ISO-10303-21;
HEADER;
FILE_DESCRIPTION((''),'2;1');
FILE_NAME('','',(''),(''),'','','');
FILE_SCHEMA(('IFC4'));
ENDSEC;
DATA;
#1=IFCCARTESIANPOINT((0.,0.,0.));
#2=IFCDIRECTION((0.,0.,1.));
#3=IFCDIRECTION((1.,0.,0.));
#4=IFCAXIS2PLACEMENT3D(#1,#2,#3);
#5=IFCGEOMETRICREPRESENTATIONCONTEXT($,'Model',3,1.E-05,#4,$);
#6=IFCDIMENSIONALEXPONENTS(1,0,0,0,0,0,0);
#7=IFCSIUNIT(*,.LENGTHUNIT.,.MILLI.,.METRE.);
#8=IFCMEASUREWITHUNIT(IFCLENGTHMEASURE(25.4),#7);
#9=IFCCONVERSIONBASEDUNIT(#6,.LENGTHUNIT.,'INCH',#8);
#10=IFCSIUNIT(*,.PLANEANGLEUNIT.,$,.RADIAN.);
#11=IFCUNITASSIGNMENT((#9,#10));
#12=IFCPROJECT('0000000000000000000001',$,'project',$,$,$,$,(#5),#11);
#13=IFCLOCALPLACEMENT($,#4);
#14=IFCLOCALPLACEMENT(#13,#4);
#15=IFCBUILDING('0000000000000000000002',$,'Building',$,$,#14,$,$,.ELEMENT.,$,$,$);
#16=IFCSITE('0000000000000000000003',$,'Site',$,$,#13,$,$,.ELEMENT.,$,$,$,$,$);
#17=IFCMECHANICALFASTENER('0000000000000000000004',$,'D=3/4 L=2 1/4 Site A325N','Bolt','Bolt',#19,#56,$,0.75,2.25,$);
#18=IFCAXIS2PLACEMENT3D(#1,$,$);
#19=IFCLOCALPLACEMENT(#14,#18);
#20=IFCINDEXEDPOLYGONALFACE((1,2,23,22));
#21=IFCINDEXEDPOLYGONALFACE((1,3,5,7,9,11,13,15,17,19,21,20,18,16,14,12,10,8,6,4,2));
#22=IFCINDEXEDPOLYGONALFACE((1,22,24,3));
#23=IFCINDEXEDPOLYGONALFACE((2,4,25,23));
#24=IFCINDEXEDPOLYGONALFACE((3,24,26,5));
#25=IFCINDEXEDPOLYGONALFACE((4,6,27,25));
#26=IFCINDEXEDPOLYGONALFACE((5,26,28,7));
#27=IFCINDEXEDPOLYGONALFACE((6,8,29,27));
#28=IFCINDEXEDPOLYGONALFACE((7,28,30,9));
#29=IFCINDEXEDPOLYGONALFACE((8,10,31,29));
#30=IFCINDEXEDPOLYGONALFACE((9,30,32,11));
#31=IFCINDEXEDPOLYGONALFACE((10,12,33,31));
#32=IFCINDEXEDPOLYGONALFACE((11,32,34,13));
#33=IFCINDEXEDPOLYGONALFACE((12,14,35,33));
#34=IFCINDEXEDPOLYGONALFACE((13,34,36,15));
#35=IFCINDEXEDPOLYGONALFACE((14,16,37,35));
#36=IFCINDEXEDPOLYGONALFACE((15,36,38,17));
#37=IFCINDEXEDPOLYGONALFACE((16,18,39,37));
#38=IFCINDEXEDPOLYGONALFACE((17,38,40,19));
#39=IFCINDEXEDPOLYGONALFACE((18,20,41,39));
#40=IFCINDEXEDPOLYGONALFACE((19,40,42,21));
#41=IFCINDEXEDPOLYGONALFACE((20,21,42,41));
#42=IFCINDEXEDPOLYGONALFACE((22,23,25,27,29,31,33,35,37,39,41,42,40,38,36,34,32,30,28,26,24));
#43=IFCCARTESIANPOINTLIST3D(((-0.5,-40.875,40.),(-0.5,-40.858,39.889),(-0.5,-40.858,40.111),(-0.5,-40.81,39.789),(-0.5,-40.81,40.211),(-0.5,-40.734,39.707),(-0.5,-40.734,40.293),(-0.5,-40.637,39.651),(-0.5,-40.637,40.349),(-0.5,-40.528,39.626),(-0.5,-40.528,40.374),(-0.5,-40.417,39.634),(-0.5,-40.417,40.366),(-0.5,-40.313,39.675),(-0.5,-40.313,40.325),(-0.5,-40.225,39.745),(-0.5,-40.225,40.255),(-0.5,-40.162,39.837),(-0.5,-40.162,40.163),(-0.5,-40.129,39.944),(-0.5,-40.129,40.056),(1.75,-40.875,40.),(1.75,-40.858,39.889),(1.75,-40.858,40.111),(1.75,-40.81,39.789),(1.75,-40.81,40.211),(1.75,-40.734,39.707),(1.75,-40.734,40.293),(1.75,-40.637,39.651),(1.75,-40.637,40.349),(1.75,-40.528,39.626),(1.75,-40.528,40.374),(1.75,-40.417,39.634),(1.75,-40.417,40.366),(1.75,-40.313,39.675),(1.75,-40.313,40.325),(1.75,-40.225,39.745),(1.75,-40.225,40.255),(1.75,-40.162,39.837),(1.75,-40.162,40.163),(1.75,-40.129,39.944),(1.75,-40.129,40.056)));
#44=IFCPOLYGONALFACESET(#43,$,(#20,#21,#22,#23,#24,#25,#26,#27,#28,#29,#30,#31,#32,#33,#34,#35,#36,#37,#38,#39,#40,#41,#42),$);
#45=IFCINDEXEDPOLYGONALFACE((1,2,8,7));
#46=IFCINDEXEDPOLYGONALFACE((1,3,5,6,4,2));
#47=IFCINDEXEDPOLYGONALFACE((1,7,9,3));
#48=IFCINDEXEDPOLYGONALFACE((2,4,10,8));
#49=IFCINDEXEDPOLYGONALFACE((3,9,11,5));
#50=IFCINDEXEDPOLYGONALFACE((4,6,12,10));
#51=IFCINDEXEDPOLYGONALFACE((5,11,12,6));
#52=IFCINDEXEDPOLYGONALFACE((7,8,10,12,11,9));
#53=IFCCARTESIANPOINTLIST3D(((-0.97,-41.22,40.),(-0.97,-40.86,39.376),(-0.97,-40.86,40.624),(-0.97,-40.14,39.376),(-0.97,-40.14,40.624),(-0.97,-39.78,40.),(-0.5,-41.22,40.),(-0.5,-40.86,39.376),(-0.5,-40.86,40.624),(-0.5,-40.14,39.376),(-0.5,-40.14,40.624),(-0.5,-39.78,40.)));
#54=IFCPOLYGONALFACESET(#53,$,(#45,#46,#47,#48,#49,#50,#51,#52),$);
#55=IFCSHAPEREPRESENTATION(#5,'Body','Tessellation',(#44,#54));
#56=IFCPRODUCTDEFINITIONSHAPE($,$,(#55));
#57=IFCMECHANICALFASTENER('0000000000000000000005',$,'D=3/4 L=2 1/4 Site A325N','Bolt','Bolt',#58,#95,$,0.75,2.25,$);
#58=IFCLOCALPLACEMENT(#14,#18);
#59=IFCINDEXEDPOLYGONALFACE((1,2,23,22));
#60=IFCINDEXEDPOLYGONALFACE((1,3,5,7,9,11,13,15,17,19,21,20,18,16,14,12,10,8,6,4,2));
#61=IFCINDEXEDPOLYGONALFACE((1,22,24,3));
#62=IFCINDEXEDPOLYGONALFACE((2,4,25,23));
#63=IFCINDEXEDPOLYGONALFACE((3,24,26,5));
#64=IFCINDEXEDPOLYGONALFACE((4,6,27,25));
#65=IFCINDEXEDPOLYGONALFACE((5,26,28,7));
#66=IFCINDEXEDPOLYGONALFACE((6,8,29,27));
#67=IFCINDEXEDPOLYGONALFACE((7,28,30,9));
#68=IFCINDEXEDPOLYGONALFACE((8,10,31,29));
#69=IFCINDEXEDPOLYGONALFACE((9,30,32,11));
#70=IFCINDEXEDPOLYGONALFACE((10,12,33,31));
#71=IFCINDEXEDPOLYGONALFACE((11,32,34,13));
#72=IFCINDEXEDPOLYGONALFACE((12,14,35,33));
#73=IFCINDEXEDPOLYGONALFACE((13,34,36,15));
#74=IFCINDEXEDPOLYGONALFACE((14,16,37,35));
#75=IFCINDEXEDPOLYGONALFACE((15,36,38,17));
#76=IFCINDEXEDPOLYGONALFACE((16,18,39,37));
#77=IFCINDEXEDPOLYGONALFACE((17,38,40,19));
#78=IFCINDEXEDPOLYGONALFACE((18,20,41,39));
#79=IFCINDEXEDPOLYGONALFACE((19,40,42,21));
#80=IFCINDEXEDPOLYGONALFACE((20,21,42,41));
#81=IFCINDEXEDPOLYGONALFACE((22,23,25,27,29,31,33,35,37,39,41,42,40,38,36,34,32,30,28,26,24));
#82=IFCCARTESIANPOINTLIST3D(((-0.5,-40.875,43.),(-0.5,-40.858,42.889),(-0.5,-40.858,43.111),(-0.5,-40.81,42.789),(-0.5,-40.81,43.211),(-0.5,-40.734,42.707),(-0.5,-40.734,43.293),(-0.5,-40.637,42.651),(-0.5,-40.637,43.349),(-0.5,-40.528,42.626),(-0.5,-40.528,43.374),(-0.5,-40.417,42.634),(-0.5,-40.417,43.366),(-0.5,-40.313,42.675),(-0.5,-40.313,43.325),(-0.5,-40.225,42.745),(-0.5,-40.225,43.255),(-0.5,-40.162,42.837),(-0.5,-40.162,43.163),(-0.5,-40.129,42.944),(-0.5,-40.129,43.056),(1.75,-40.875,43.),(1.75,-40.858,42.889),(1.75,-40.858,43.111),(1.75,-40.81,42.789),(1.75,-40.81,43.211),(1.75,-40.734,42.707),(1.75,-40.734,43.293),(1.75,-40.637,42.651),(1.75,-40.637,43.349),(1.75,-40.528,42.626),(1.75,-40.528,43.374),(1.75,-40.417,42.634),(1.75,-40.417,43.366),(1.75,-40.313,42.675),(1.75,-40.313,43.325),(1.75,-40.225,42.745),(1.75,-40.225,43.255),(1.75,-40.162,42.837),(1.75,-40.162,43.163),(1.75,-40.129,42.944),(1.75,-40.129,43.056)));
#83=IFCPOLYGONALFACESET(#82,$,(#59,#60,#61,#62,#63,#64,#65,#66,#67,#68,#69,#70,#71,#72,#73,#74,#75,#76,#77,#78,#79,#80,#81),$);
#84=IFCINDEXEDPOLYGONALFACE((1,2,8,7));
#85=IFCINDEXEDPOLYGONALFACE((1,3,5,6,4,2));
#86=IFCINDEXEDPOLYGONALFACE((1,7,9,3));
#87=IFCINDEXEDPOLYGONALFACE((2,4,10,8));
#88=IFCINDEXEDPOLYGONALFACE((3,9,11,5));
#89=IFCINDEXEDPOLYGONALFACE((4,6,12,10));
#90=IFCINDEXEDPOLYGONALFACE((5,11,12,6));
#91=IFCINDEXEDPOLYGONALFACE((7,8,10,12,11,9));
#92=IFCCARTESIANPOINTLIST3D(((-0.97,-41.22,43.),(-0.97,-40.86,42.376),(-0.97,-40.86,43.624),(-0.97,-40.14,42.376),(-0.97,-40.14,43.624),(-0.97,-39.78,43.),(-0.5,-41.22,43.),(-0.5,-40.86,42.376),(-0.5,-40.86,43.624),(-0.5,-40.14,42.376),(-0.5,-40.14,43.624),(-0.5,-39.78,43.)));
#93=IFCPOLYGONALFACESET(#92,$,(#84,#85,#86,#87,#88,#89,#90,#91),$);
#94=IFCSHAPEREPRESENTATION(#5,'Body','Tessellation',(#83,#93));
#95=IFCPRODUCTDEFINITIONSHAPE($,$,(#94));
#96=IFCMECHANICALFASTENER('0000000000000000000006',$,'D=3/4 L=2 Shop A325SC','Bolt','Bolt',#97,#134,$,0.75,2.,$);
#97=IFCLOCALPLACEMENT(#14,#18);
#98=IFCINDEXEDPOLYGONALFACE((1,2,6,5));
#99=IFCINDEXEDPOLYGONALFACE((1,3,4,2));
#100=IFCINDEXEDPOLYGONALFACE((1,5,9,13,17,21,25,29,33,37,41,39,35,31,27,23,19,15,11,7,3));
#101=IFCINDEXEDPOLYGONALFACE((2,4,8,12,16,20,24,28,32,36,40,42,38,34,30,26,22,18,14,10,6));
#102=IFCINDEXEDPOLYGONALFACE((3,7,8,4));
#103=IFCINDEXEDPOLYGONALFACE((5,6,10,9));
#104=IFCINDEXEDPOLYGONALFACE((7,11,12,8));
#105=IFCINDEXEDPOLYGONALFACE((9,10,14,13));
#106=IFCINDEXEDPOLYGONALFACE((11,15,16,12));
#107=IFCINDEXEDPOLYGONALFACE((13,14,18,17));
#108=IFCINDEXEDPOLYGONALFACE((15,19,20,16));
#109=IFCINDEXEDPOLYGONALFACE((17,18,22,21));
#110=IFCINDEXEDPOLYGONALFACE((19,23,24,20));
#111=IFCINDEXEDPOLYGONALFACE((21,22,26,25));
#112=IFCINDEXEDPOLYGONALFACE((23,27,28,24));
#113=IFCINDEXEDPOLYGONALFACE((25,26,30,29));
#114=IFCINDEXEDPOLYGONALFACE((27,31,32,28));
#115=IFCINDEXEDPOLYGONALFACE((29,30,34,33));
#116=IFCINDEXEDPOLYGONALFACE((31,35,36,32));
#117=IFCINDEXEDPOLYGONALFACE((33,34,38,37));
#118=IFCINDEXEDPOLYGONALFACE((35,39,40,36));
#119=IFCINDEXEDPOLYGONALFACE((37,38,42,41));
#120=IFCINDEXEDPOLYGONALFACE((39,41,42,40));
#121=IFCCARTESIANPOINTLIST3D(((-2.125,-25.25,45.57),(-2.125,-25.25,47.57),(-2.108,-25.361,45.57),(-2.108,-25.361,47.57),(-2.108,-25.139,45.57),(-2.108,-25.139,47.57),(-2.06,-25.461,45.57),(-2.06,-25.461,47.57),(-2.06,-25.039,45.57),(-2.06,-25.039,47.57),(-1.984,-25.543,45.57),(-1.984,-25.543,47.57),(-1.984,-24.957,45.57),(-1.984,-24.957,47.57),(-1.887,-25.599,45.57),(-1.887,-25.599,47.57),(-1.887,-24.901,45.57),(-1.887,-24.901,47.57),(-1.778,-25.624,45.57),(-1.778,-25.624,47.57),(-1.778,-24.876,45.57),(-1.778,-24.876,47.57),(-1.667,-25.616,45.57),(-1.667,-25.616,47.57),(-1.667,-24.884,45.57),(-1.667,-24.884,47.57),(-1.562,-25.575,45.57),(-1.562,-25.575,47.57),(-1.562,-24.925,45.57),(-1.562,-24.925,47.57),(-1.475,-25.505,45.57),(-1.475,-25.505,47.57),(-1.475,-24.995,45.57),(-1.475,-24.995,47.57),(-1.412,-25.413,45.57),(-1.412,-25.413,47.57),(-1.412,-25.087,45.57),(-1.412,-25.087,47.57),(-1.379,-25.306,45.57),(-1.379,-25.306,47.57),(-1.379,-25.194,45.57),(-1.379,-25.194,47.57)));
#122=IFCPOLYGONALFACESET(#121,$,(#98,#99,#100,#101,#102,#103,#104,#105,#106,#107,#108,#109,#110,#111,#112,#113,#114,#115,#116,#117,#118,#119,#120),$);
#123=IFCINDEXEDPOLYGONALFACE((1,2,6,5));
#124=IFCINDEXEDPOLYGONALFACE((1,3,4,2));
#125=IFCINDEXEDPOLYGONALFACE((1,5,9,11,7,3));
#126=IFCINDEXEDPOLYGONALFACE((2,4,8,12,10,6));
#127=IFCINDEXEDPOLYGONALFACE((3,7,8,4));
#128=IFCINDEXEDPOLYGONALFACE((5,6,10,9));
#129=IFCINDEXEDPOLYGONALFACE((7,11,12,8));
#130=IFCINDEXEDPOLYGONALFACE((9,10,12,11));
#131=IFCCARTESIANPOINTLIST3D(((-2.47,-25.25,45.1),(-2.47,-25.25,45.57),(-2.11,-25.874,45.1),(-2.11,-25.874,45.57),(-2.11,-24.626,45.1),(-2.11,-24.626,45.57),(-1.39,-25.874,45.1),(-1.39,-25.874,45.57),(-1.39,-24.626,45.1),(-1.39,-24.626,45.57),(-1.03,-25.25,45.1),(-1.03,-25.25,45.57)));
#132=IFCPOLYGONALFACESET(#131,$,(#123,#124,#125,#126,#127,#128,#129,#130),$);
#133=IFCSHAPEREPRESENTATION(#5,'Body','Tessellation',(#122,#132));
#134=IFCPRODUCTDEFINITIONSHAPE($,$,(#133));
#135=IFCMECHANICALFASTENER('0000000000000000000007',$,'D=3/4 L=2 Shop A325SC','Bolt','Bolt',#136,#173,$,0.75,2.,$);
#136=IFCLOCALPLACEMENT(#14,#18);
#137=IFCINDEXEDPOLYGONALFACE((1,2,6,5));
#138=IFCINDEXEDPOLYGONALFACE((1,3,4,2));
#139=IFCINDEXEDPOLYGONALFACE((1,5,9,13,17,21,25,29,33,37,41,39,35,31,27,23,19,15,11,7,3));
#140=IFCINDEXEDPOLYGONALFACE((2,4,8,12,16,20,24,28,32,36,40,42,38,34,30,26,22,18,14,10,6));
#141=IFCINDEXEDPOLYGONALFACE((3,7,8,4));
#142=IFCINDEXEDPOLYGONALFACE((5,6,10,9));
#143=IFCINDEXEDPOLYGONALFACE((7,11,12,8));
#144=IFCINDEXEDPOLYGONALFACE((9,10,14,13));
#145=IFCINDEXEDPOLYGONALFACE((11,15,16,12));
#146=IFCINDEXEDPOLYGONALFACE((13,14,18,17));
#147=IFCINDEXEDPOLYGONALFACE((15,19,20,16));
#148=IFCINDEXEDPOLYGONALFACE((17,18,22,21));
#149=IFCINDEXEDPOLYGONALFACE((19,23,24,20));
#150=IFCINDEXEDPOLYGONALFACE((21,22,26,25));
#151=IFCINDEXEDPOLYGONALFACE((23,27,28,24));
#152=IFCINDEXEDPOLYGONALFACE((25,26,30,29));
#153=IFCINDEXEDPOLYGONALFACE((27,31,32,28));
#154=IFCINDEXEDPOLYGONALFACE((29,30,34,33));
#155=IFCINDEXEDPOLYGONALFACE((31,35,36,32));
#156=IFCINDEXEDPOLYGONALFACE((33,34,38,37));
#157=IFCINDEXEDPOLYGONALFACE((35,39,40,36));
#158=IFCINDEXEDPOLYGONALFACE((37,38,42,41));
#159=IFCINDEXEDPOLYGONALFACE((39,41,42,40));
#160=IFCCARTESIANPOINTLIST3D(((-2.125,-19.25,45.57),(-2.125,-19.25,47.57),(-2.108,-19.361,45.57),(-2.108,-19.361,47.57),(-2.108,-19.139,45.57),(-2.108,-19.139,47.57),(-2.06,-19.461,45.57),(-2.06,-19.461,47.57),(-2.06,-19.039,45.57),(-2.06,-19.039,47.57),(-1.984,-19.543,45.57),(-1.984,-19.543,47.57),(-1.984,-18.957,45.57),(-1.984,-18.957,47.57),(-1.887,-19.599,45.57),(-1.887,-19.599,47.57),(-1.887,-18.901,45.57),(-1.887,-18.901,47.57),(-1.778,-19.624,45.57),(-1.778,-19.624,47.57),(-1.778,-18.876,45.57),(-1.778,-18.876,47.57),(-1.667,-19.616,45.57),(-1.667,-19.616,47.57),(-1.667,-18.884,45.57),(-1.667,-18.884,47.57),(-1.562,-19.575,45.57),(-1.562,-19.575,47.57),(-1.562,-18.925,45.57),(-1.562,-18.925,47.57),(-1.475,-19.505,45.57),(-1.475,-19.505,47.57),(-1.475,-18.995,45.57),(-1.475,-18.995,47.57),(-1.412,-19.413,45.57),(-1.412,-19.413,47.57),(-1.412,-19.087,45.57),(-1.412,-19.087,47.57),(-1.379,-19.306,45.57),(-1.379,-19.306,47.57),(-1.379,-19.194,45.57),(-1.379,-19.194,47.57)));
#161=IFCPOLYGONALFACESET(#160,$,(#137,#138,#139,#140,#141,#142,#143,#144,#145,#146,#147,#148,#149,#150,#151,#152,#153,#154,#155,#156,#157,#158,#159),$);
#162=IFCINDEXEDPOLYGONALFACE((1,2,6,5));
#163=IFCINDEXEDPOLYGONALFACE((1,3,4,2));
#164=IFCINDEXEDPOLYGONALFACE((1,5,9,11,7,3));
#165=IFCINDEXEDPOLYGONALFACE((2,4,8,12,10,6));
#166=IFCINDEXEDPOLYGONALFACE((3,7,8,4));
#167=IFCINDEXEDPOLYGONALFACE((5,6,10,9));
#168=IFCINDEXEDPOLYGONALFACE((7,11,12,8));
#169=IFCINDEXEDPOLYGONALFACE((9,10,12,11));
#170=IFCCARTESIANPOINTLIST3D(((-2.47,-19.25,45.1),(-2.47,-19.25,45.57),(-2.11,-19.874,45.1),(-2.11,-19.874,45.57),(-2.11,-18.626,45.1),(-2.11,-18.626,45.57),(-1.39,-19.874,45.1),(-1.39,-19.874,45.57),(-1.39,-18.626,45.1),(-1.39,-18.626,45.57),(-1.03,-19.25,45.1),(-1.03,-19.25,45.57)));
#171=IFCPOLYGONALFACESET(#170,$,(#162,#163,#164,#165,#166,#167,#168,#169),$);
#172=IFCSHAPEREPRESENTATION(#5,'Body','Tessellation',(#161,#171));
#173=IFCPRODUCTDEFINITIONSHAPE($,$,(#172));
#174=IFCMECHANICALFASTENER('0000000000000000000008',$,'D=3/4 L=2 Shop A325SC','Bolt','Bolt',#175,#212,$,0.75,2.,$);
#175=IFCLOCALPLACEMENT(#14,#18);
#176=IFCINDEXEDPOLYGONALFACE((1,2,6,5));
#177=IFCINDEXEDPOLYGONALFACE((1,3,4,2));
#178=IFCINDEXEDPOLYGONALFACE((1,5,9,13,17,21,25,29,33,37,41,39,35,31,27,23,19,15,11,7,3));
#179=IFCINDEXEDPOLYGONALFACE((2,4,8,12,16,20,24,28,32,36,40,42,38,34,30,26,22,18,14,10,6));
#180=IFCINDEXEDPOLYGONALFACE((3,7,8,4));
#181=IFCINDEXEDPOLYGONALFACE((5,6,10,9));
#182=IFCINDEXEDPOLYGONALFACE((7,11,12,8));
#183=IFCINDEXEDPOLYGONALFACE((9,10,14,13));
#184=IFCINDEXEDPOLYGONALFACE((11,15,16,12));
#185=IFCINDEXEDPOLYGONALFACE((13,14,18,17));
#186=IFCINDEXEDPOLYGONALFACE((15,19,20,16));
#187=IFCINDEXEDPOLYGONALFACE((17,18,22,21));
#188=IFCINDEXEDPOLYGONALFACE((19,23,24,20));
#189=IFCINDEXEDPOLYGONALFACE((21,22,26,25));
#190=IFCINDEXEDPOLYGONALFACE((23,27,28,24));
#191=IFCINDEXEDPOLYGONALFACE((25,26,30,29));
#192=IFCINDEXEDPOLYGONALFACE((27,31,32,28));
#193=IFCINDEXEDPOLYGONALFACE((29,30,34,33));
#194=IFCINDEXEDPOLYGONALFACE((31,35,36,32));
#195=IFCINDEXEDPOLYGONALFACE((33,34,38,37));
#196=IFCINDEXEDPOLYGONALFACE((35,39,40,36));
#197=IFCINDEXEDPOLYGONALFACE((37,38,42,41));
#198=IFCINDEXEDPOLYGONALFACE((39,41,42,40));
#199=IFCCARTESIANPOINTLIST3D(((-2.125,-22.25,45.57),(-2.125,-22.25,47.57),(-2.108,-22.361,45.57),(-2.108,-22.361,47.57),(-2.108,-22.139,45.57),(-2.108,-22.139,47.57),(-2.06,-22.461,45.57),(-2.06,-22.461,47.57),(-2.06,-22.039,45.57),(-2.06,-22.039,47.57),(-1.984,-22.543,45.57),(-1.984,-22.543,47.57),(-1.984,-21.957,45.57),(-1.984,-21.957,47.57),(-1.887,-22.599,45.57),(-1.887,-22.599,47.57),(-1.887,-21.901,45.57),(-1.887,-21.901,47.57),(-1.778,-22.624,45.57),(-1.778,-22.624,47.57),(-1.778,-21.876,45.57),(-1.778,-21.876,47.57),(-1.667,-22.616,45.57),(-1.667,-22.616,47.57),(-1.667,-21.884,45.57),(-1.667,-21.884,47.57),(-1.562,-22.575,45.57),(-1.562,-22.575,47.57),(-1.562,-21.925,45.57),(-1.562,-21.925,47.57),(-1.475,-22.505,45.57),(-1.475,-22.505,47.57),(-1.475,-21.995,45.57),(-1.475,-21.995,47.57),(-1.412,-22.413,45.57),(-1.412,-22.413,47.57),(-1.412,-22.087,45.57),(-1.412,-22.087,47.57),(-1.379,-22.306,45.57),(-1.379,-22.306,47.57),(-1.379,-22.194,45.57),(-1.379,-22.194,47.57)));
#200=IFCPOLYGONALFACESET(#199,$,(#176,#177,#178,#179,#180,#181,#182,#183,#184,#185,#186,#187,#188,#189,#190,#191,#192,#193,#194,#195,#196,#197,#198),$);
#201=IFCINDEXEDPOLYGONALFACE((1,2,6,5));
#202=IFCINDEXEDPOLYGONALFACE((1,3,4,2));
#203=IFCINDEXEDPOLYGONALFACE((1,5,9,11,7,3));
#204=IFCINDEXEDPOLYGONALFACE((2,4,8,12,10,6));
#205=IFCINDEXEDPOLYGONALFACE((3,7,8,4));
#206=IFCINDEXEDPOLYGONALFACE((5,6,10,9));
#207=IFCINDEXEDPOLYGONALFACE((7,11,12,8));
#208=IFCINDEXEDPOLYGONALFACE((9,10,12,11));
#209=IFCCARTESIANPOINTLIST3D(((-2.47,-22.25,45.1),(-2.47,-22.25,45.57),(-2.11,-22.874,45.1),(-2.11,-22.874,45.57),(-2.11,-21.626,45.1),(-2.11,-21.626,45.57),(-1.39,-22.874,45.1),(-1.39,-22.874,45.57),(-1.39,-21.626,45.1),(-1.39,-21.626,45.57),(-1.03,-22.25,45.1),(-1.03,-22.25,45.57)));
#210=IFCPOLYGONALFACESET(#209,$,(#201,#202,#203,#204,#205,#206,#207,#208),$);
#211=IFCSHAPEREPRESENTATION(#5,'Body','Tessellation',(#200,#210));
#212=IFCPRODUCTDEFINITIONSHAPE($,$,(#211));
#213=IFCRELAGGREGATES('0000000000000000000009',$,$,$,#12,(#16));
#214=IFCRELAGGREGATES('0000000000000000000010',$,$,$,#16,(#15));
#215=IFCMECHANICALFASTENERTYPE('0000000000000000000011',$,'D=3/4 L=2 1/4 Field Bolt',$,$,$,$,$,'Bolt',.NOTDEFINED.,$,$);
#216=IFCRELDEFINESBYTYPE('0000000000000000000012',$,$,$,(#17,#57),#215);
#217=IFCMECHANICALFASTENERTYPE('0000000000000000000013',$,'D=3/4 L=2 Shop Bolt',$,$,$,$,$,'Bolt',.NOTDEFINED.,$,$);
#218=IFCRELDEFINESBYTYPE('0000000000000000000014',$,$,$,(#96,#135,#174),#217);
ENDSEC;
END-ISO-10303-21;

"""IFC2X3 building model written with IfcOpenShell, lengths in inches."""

from ifc_helpers import new_model, entity, si_unit, converted_unit, frame, origin_with_axes, origin_2d_with_axis, place, context, project, spatial, polyline, circle, outline, extrude, source, transform, mapped, type_object, type_shapes, element, save


model = new_model("IFC2X3")

# Units and contexts
model_context = context("Model", 3, precision=1e-05, world=origin_with_axes())
ifc_project = project(units=[converted_unit("LENGTHUNIT", "INCH", entity("IfcLengthMeasure", 25.4), si_unit("LENGTHUNIT", "METRE", prefix="MILLI"), dimensions=[1, 0, 0, 0, 0, 0, 0]), si_unit("PLANEANGLEUNIT", "RADIAN")], contexts=[model_context])

# Site, building
site_placement = place(None, origin_with_axes())
site = spatial("IfcSite", under=ifc_project, at=site_placement, Name="Site", CompositionType="ELEMENT")
building_placement = place(site_placement, origin_with_axes())
building = spatial("IfcBuilding", under=site, at=building_placement, Name="Building", CompositionType="ELEMENT")

# Shared definitions
assembly_1_placement = place(building_placement, frame((0.0, 0.0, 46.0), z_axis=(0.0, 0.0, 1.0), x_axis=(0.0, -1.0, 0.0)))

# Mechanical fasteners
mechanical_fastener_type_1 = type_object("IfcMechanicalFastenerType", Name="D=3/4 L=2 1/4 Field Bolt", ElementType="Bolt")
shared_shape_1 = source(origin_with_axes(), model_context, "Body", "SweptSolid", [
    extrude(circle(Radius=0.375, at=origin_2d_with_axis()), frame((0.0, 0.0, 0.0), z_axis=(1.0, 0.0, 0.0), x_axis=(0.0, 1.0, 0.0)), (0.0, 0.0, 1.0), 2.25),
    extrude(outline(polyline([(-0.72, 0.0), (-0.36, 0.624), (0.36, 0.624), (0.72, 0.0), (0.36, -0.624), (-0.36, -0.624), (-0.72, 0.0)])), frame((0.0, 0.0, 0.0), z_axis=(1.0, 0.0, 0.0), x_axis=(0.0, 1.0, 0.0)), (0.0, 0.0, -1.0), 0.47),
])
type_shapes(mechanical_fastener_type_1, [shared_shape_1])
placement_1 = place(building_placement, frame((0.0, -43.0, 46.0), z_axis=(0.0, 0.0, 1.0), x_axis=(1.0, 0.0, 0.0)))
placement_2 = place(placement_1, frame((-0.5, 2.5, -3.0), z_axis=(0.0, 0.0, -1.0), x_axis=(1.0, 0.0, 0.0)))
for number, where, z_axis, x_axis, name in (
    (1, (0.0, 0.0, 3.0), (0.0, 0.0, 1.0), (1.0, 0.0, 0.0), "D=3/4 L=2 1/4 Site A325N"),
    (2, (0.0, 0.0, 0.0), (0.0, 0.0, 1.0), (1.0, 0.0, 0.0), "D=3/4 L=2 1/4 Site A325N"),
):
    element("IfcMechanicalFastener", number, at=place(placement_2, frame(where, z_axis=z_axis, x_axis=x_axis)), type_object=mechanical_fastener_type_1, Name=name, Description="Bolt", ObjectType="Bolt", NominalDiameter=0.75, NominalLength=2.25, context=model_context, shape_type="MappedRepresentation", body=[
        mapped(shared_shape_1, transform((0.0, 0.0, 0.0), scale=1.0)),
    ])
mechanical_fastener_type_2 = type_object("IfcMechanicalFastenerType", Name="D=3/4 L=2 Shop Bolt", ElementType="Bolt")
shared_shape_2 = source(origin_with_axes(), model_context, "Body", "SweptSolid", [
    extrude(circle(Radius=0.375, at=origin_2d_with_axis()), frame((0.0, 0.0, 0.0), z_axis=(1.0, 0.0, 0.0), x_axis=(0.0, 1.0, 0.0)), (0.0, 0.0, 1.0), 2.0),
    extrude(outline(polyline([(-0.72, 0.0), (-0.36, 0.624), (0.36, 0.624), (0.72, 0.0), (0.36, -0.624), (-0.36, -0.624), (-0.72, 0.0)])), frame((0.0, 0.0, 0.0), z_axis=(1.0, 0.0, 0.0), x_axis=(0.0, 1.0, 0.0)), (0.0, 0.0, -1.0), 0.47),
])
type_shapes(mechanical_fastener_type_2, [shared_shape_2])
placement_3 = place(assembly_1_placement, frame((25.25, -1.75, -0.43), z_axis=(1.0, 0.0, 0.0), x_axis=(0.0, 0.0, 1.0)))
for number, where, z_axis, x_axis, name in (
    (3, (0.0, 0.0, 0.0), (0.0, 0.0, 1.0), (1.0, 0.0, 0.0), "D=3/4 L=2 Shop A325SC"),
    (4, (0.0, 0.0, -6.0), (0.0, 0.0, 1.0), (1.0, 0.0, 0.0), "D=3/4 L=2 Shop A325SC"),
    (5, (0.0, 0.0, -3.0), (0.0, 0.0, 1.0), (1.0, 0.0, 0.0), "D=3/4 L=2 Shop A325SC"),
):
    element("IfcMechanicalFastener", number, at=place(placement_3, frame(where, z_axis=z_axis, x_axis=x_axis)), type_object=mechanical_fastener_type_2, Name=name, Description="Bolt", ObjectType="Bolt", NominalDiameter=0.75, NominalLength=2.0, context=model_context, shape_type="MappedRepresentation", body=[
        mapped(shared_shape_2, transform((0.0, 0.0, 0.0), scale=1.0)),
    ])

save(model, "model.ifc")
